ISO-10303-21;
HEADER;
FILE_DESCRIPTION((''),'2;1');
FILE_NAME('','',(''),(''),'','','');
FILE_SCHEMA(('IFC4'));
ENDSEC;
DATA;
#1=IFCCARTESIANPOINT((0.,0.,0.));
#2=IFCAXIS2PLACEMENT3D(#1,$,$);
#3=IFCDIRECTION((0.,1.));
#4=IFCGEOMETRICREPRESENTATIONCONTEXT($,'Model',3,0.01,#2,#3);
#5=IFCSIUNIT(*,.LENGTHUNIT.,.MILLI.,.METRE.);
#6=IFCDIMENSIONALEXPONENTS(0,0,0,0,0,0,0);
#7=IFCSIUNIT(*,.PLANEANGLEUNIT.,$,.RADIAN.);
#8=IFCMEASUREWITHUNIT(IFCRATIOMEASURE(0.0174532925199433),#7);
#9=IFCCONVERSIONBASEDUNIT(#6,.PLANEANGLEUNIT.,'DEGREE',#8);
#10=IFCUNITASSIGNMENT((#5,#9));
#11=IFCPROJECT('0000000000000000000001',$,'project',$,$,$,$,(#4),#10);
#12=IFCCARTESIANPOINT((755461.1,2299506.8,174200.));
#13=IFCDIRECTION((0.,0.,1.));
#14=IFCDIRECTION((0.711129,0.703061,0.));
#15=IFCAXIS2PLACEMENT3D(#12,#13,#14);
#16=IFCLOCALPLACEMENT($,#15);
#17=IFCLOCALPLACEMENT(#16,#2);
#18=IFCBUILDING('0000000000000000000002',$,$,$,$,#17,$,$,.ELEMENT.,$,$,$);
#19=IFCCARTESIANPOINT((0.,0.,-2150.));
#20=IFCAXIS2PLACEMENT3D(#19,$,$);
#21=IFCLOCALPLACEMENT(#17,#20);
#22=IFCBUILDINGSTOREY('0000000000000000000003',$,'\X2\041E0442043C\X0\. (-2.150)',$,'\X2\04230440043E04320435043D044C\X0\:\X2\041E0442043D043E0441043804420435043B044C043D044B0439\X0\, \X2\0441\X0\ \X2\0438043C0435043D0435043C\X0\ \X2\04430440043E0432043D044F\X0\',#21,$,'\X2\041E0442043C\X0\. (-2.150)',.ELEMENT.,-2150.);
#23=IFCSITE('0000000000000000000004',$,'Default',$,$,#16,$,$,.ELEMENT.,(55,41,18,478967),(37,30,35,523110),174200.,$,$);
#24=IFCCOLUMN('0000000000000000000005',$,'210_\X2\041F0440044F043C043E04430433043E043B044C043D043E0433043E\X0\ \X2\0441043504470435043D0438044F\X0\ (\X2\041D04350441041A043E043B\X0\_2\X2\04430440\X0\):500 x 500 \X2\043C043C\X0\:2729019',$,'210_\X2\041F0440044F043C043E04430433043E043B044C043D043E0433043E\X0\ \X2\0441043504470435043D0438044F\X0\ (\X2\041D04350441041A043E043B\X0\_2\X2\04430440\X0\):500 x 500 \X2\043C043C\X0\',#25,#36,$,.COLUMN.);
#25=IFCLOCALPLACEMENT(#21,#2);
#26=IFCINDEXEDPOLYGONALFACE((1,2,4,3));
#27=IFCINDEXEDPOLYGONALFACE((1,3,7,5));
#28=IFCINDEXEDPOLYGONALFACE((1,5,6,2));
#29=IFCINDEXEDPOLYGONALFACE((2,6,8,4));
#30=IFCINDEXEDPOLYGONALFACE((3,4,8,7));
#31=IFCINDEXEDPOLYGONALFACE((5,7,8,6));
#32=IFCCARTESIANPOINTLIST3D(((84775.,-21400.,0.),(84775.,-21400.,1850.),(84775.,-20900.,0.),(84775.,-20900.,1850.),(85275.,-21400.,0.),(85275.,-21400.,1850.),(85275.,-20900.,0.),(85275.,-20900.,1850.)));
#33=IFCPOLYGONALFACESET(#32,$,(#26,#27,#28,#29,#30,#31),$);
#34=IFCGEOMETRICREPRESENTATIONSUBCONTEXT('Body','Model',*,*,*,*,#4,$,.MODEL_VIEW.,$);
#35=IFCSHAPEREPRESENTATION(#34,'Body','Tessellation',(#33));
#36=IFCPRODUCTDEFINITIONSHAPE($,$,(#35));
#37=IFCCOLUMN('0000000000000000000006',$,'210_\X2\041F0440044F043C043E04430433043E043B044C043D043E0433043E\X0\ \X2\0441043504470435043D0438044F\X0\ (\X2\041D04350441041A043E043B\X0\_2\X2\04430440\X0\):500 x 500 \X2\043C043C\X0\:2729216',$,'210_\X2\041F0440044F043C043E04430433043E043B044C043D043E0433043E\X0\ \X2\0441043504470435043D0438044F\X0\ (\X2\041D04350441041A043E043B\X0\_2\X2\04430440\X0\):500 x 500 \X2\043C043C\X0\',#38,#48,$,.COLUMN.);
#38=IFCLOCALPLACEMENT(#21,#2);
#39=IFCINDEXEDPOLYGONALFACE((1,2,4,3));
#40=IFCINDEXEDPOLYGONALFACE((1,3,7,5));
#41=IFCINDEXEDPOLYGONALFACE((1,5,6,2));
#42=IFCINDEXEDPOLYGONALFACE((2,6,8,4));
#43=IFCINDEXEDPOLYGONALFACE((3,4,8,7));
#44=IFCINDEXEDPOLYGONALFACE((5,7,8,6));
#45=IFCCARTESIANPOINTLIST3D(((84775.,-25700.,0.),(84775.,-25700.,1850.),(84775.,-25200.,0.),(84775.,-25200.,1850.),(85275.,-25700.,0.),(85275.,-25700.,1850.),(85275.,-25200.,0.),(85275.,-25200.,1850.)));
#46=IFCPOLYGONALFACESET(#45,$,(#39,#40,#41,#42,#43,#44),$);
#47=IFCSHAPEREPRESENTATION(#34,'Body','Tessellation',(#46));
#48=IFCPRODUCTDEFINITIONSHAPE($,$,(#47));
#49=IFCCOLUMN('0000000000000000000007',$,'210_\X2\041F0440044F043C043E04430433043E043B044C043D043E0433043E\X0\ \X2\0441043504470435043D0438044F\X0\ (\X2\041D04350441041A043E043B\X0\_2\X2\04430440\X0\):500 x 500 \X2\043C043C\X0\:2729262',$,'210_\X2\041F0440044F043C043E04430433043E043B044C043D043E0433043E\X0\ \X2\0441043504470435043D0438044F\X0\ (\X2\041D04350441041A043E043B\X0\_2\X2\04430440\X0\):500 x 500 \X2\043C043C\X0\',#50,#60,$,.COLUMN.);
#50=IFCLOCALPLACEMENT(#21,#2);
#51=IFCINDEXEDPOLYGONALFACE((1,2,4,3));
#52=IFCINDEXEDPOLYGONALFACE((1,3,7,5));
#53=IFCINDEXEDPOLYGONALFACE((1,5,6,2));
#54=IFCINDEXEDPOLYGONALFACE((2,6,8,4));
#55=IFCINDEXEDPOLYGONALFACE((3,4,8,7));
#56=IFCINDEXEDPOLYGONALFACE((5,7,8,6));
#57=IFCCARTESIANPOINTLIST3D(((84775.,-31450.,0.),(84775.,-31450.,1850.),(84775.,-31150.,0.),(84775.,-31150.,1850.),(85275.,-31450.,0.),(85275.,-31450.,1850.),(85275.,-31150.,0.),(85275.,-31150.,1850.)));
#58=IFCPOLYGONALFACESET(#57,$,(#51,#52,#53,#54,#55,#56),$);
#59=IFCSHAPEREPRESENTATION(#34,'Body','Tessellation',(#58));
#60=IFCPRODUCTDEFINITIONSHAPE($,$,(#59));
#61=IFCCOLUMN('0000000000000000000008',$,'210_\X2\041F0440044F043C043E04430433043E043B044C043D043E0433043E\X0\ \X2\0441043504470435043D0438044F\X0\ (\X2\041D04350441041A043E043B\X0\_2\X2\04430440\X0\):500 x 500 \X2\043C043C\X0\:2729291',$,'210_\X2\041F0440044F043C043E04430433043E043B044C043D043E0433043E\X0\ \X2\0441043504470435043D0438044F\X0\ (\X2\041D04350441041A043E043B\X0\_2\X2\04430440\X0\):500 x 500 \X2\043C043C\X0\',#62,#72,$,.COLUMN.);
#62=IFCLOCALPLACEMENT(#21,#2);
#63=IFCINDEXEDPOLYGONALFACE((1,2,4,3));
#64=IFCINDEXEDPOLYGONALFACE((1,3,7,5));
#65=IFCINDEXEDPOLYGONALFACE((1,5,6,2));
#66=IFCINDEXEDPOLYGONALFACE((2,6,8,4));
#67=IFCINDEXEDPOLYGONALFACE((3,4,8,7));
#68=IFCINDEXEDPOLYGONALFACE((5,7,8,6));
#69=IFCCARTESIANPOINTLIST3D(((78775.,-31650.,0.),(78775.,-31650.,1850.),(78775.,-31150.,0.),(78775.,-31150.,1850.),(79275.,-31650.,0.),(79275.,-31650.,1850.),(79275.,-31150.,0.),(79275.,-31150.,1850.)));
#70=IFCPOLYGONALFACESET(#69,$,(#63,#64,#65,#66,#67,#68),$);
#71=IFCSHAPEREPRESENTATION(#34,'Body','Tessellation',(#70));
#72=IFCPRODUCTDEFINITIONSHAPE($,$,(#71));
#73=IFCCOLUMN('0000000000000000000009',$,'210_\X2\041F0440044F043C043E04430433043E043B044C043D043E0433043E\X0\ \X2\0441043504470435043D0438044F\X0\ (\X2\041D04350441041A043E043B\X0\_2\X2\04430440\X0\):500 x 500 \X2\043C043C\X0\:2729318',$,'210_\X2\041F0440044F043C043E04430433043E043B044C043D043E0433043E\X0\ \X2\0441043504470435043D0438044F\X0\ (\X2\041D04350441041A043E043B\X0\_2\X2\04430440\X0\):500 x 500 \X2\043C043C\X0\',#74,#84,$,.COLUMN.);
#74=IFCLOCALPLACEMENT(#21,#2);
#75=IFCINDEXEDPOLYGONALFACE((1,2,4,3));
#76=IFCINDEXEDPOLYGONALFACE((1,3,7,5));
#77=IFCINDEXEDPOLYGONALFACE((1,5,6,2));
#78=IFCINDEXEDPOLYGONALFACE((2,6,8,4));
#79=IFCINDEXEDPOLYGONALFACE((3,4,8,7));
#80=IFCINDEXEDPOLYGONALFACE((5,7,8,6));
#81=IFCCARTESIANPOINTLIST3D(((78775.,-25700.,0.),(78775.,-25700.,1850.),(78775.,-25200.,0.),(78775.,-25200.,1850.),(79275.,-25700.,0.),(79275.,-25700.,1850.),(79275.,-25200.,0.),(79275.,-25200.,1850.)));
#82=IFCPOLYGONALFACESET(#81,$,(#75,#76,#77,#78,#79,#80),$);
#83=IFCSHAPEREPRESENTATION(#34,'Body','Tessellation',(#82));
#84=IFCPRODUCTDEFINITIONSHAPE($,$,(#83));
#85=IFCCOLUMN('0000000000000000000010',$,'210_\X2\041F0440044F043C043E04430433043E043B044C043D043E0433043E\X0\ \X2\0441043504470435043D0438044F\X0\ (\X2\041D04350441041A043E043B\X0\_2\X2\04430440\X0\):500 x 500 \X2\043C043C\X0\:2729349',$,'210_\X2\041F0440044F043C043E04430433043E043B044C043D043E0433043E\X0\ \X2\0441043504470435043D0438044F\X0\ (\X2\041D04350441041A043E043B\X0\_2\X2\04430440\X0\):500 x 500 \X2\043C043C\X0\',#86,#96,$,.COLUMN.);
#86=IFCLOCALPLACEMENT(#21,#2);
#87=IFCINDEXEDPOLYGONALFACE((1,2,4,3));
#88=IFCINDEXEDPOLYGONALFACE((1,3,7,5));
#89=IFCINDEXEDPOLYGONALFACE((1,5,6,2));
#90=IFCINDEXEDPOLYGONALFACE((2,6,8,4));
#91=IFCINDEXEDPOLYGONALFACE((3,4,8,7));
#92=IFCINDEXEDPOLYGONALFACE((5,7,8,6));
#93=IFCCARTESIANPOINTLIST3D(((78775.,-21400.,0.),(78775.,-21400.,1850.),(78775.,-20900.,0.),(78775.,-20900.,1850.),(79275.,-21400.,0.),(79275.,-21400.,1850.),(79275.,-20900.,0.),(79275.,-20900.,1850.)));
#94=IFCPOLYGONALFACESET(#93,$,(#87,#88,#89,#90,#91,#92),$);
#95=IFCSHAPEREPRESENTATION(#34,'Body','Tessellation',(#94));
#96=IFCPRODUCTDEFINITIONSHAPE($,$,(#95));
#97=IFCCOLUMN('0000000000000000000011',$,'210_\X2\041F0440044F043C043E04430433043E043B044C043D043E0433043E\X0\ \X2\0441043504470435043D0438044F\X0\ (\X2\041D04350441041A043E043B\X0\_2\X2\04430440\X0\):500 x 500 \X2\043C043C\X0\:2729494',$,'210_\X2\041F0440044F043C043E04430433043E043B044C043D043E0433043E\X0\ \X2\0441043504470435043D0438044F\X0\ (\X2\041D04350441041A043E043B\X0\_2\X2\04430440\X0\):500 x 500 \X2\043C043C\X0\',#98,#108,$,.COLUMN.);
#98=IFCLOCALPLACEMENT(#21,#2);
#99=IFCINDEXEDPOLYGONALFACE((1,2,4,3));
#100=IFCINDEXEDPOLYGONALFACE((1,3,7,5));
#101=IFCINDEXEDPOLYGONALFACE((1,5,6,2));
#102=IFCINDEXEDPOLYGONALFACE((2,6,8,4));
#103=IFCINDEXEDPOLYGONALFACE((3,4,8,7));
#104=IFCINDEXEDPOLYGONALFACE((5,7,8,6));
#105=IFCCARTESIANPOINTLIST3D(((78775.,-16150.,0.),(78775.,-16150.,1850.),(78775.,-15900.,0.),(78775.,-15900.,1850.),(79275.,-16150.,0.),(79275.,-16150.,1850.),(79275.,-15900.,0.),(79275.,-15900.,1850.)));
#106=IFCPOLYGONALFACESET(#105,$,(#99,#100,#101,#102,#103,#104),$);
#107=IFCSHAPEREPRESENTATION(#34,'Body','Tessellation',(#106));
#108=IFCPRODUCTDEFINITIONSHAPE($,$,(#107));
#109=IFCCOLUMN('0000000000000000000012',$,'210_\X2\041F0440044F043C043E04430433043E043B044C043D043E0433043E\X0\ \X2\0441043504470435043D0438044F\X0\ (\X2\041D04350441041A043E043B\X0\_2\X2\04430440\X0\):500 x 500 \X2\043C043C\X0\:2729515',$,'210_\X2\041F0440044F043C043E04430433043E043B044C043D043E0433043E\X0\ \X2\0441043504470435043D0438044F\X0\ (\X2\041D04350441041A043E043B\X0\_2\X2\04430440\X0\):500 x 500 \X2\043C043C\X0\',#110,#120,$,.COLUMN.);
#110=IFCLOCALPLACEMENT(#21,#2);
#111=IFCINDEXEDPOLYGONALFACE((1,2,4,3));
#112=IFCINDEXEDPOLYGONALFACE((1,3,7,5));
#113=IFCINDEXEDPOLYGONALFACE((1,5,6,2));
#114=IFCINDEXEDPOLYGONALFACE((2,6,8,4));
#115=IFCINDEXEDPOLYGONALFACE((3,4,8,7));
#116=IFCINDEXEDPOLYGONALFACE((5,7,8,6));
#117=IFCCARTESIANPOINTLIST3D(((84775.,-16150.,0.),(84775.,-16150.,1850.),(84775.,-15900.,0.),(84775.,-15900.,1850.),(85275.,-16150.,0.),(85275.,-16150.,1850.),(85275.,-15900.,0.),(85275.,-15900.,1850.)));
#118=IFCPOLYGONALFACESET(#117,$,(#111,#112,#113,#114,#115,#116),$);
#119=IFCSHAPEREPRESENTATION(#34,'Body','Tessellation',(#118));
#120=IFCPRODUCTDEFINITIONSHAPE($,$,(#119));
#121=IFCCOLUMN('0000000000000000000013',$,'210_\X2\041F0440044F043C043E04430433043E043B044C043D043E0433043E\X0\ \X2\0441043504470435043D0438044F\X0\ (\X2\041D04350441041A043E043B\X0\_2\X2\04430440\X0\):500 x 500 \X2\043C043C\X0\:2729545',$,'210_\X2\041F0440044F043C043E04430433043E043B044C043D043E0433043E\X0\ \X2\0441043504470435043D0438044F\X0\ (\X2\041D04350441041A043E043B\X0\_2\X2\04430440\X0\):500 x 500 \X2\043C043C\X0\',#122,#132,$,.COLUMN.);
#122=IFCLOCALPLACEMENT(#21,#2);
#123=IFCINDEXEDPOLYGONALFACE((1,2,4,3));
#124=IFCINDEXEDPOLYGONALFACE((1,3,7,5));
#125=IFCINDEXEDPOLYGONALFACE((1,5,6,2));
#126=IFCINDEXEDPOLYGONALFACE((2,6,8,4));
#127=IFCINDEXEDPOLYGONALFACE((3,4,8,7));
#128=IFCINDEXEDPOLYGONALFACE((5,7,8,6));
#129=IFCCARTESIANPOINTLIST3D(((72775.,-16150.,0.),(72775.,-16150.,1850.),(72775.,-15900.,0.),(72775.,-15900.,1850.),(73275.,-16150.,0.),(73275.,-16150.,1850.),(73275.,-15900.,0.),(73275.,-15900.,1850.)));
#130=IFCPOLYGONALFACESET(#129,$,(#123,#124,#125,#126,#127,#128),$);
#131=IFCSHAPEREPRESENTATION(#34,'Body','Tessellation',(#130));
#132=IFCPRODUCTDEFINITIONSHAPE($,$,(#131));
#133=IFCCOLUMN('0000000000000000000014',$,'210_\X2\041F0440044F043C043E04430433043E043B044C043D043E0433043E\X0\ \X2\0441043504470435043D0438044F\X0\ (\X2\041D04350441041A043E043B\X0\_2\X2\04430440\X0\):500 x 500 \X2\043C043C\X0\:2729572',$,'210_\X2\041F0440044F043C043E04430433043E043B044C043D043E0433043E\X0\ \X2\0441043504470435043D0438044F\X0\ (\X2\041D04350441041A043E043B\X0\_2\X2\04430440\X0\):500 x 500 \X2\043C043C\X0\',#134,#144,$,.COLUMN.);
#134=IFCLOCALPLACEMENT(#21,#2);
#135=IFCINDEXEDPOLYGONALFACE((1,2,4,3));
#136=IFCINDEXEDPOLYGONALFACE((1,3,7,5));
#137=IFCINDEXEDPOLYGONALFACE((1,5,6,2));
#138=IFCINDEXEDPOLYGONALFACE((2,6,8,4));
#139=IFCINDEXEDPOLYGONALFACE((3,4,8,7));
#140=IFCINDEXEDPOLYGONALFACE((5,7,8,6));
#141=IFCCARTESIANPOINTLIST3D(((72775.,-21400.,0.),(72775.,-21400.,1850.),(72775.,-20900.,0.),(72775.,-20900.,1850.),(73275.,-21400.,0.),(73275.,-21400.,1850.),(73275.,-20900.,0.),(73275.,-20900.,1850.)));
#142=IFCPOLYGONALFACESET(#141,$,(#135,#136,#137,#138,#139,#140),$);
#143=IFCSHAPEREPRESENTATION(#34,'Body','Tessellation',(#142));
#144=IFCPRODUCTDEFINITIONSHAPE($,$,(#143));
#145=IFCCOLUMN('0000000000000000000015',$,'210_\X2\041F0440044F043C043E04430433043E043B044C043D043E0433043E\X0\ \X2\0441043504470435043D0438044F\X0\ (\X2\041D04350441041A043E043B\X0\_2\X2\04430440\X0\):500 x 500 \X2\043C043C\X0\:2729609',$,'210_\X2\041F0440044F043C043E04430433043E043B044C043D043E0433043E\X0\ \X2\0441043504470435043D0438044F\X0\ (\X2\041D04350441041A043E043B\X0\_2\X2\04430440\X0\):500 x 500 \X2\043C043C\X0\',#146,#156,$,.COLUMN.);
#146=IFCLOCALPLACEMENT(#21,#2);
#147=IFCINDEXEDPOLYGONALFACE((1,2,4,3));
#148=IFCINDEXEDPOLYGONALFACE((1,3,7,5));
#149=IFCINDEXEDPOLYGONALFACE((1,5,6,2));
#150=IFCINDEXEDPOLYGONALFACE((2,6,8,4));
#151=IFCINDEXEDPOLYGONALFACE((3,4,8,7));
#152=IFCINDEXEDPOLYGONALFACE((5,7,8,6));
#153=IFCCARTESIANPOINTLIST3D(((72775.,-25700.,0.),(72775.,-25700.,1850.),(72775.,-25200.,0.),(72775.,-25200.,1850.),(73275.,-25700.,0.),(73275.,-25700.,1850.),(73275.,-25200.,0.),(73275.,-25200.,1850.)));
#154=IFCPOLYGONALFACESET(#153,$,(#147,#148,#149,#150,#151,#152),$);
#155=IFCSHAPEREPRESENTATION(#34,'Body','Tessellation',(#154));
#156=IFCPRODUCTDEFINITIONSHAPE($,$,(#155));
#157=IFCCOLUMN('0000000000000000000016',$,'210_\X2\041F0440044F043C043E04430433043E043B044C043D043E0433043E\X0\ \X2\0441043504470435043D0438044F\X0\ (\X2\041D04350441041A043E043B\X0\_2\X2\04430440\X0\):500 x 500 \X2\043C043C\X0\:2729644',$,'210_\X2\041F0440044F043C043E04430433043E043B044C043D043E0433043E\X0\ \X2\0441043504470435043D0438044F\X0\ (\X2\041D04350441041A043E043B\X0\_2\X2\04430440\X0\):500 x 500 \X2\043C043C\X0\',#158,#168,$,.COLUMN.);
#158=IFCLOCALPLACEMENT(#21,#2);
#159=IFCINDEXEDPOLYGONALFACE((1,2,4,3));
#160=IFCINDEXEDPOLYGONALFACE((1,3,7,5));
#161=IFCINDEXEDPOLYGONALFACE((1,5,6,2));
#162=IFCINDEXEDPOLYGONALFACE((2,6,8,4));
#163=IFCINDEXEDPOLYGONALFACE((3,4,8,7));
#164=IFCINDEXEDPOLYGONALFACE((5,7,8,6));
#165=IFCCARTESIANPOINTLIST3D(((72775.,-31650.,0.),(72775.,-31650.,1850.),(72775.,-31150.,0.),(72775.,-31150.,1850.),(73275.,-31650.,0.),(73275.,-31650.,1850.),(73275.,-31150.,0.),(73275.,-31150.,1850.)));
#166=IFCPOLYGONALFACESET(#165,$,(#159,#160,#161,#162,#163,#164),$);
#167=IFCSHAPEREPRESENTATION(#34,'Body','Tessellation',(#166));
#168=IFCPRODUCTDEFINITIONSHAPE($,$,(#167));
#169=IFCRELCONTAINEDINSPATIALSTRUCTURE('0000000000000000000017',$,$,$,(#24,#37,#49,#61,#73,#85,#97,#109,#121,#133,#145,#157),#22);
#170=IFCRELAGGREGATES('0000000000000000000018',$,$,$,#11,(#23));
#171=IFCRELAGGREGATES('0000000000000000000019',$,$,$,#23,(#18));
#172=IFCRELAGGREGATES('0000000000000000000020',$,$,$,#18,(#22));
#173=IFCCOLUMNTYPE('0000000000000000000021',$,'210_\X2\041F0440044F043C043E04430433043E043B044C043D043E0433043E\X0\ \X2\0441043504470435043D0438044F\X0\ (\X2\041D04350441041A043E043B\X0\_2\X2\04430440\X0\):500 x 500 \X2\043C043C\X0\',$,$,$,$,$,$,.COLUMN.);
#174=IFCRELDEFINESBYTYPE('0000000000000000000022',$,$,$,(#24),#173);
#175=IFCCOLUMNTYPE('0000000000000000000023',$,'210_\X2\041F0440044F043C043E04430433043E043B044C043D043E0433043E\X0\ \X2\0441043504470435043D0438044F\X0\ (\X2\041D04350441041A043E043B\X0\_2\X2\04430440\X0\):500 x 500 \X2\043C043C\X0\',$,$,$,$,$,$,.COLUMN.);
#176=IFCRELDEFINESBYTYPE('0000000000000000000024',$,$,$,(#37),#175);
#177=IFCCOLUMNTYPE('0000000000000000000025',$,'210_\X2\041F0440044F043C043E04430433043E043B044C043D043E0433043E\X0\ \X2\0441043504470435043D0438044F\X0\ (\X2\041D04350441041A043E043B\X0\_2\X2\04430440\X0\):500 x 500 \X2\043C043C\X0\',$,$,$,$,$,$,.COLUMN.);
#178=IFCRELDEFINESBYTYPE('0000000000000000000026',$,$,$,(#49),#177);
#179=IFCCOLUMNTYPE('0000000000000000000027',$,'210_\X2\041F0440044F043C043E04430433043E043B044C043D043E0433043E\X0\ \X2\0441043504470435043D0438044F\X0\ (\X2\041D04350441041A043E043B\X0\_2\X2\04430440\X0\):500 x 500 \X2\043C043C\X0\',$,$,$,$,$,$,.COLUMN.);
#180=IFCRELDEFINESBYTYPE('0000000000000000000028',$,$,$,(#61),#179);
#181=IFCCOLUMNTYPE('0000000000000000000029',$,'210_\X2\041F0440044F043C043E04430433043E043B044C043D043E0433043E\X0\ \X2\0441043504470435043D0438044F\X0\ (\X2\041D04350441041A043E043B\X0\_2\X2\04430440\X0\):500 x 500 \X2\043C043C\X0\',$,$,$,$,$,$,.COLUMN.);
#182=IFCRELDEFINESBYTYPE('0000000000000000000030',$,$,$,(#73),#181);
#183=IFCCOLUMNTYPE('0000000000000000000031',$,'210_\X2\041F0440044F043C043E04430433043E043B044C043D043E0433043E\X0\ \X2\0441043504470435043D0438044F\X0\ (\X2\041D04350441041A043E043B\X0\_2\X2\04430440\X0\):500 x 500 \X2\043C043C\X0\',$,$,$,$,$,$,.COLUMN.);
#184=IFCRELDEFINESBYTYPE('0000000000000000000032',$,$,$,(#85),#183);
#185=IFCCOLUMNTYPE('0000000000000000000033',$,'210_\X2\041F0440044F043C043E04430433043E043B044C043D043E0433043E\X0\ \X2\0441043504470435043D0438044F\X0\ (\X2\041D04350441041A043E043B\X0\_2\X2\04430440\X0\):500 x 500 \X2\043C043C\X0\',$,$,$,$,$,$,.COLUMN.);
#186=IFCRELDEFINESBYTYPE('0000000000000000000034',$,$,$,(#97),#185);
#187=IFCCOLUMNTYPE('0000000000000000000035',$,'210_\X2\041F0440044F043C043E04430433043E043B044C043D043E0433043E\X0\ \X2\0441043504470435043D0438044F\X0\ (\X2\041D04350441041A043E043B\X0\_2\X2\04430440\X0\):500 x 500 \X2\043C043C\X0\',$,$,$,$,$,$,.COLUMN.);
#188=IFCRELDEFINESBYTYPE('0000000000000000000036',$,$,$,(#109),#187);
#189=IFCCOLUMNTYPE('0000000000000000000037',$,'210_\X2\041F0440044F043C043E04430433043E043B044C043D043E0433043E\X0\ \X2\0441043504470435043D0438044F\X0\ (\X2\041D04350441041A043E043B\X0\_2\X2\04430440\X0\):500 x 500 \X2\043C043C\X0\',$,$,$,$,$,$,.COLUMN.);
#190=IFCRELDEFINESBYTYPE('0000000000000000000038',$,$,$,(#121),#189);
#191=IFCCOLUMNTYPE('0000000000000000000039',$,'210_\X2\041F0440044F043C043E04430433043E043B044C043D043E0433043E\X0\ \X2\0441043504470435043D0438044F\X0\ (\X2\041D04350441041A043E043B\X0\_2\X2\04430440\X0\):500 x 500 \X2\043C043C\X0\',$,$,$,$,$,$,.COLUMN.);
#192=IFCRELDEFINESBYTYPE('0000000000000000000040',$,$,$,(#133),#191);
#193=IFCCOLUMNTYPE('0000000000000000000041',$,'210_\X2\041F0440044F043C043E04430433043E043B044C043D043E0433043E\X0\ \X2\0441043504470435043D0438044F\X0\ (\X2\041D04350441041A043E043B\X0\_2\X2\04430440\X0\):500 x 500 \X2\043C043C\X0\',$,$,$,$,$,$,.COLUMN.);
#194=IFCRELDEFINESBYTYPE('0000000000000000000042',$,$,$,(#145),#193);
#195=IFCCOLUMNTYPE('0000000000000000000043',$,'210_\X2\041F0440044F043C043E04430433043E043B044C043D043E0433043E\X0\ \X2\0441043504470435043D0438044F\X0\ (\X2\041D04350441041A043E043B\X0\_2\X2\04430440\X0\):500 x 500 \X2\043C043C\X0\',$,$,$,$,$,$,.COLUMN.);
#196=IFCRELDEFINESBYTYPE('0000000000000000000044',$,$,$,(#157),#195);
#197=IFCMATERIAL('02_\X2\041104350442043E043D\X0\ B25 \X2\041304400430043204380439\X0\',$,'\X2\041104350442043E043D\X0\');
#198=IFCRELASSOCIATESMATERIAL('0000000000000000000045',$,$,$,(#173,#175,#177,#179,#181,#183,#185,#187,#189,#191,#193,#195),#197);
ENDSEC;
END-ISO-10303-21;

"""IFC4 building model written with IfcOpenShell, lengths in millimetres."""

from ifc_helpers import new_model, entity, si_unit, converted_unit, direction, frame, origin, place, context, subcontext, project, spatial, indexed_curve, outline, extrude, source, transform, mapped, material, type_object, type_shapes, element, save


model = new_model("IFC4")

# Units and contexts
model_context = context("Model", 3, precision=0.01, world=origin(), true_north=direction((0.0, 1.0)))
body_context = subcontext(model_context, "Body", "Model", "MODEL_VIEW")
ifc_project = project(units=[si_unit("LENGTHUNIT", "METRE", prefix="MILLI"), converted_unit("PLANEANGLEUNIT", "DEGREE", entity("IfcRatioMeasure", 0.0174532925199433), si_unit("PLANEANGLEUNIT", "RADIAN"), dimensions=[0, 0, 0, 0, 0, 0, 0])], contexts=[model_context])

# Site, building, storey
site_placement = place(None, frame((755461.1, 2299506.8, 174200.0), z_axis=(0.0, 0.0, 1.0), x_axis=(0.711129, 0.703061, 0.0)))
site = spatial("IfcSite", under=ifc_project, at=site_placement, Name="Default", CompositionType="ELEMENT", RefLatitude=(55, 41, 18, 478967), RefLongitude=(37, 30, 35, 523110), RefElevation=174200.0)
building_placement = place(site_placement, origin())
building = spatial("IfcBuilding", under=site, at=building_placement, CompositionType="ELEMENT")
storey_placement = place(building_placement, frame((0.0, 0.0, -2150.0)))
storey = spatial("IfcBuildingStorey", under=building, at=storey_placement, Name="Отм. (-2.150)", ObjectType="Уровень:Относительный, с именем уровня", LongName="Отм. (-2.150)", CompositionType="ELEMENT", Elevation=-2150.0)

# Columns
ifc_material_1 = material(Name="02_Бетон B25 Гравий", Category="Бетон")
column_type_1 = type_object("IfcColumnType", Name="210_Прямоугольного сечения (НесКол_2ур):500 x 500 мм", PredefinedType="COLUMN", material=ifc_material_1)
shared_shape_1 = source(origin(), body_context, "Body", "SweptSolid", [
    extrude(outline(indexed_curve([(-250.0, -250.0), (250.0, -250.0), (250.0, 250.0), (-250.0, 250.0), (-250.0, -250.0)], self_intersect=False)), frame((85025.0, -21150.0, -2150.0), z_axis=(0.0, 0.0, 1.0), x_axis=(0.0, -1.0, 0.0)), (0.0, 0.0, 1.0), 1850.0),
])
type_shapes(column_type_1, [shared_shape_1])
column_1_placement = place(storey_placement, frame((0.0, 0.0, 2150.0)))
element("IfcColumn", 1, at=column_1_placement, inside=storey, type_object=column_type_1, Name="210_Прямоугольного сечения (НесКол_2ур):500 x 500 мм:2729019", ObjectType="210_Прямоугольного сечения (НесКол_2ур):500 x 500 мм", PredefinedType="COLUMN", context=body_context, shape_type="MappedRepresentation", body=[
    mapped(shared_shape_1, transform((0.0, 0.0, 0.0), scale=1.0)),
])
column_type_2 = type_object("IfcColumnType", Name="210_Прямоугольного сечения (НесКол_2ур):500 x 500 мм", PredefinedType="COLUMN", material=ifc_material_1)
shared_shape_2 = source(origin(), body_context, "Body", "SweptSolid", [
    extrude(outline(indexed_curve([(-250.0, -250.0), (250.0, -250.0), (250.0, 250.0), (-250.0, 250.0), (-250.0, -250.0)], self_intersect=False)), frame((85025.0, -25450.0, -2150.0), z_axis=(0.0, 0.0, 1.0), x_axis=(0.0, -1.0, 0.0)), (0.0, 0.0, 1.0), 1850.0),
])
type_shapes(column_type_2, [shared_shape_2])
column_2_placement = place(storey_placement, frame((0.0, 0.0, 2150.0)))
element("IfcColumn", 2, at=column_2_placement, inside=storey, type_object=column_type_2, Name="210_Прямоугольного сечения (НесКол_2ур):500 x 500 мм:2729216", ObjectType="210_Прямоугольного сечения (НесКол_2ур):500 x 500 мм", PredefinedType="COLUMN", context=body_context, shape_type="MappedRepresentation", body=[
    mapped(shared_shape_2, transform((0.0, 0.0, 0.0), scale=1.0)),
])
column_type_3 = type_object("IfcColumnType", Name="210_Прямоугольного сечения (НесКол_2ур):500 x 500 мм", PredefinedType="COLUMN", material=ifc_material_1)
shared_shape_3 = source(origin(), body_context, "Body", "SweptSolid", [
    extrude(outline(indexed_curve([(-150.0, -250.0), (150.0, -250.0), (150.0, 250.0), (-150.0, 250.0), (-150.0, -250.0)], self_intersect=False)), frame((85025.0, -31300.0, -2150.0), z_axis=(0.0, 0.0, 1.0), x_axis=(0.0, -1.0, 0.0)), (0.0, 0.0, 1.0), 1850.0),
])
type_shapes(column_type_3, [shared_shape_3])
column_3_placement = place(storey_placement, frame((0.0, 0.0, 2150.0)))
element("IfcColumn", 3, at=column_3_placement, inside=storey, type_object=column_type_3, Name="210_Прямоугольного сечения (НесКол_2ур):500 x 500 мм:2729262", ObjectType="210_Прямоугольного сечения (НесКол_2ур):500 x 500 мм", PredefinedType="COLUMN", context=body_context, shape_type="MappedRepresentation", body=[
    mapped(shared_shape_3, transform((0.0, 0.0, 0.0), scale=1.0)),
])
column_type_4 = type_object("IfcColumnType", Name="210_Прямоугольного сечения (НесКол_2ур):500 x 500 мм", PredefinedType="COLUMN", material=ifc_material_1)
shared_shape_4 = source(origin(), body_context, "Body", "SweptSolid", [
    extrude(outline(indexed_curve([(-250.0, -250.0), (250.0, -250.0), (250.0, 250.0), (-250.0, 250.0), (-250.0, -250.0)], self_intersect=False)), frame((79025.0, -31400.0, -2150.0), z_axis=(0.0, 0.0, 1.0), x_axis=(0.0, -1.0, 0.0)), (0.0, 0.0, 1.0), 1850.0),
])
type_shapes(column_type_4, [shared_shape_4])
column_4_placement = place(storey_placement, frame((0.0, 0.0, 2150.0)))
element("IfcColumn", 4, at=column_4_placement, inside=storey, type_object=column_type_4, Name="210_Прямоугольного сечения (НесКол_2ур):500 x 500 мм:2729291", ObjectType="210_Прямоугольного сечения (НесКол_2ур):500 x 500 мм", PredefinedType="COLUMN", context=body_context, shape_type="MappedRepresentation", body=[
    mapped(shared_shape_4, transform((0.0, 0.0, 0.0), scale=1.0)),
])
column_type_5 = type_object("IfcColumnType", Name="210_Прямоугольного сечения (НесКол_2ур):500 x 500 мм", PredefinedType="COLUMN", material=ifc_material_1)
shared_shape_5 = source(origin(), body_context, "Body", "SweptSolid", [
    extrude(outline(indexed_curve([(-250.0, -250.0), (250.0, -250.0), (250.0, 250.0), (-250.0, 250.0), (-250.0, -250.0)], self_intersect=False)), frame((79025.0, -25450.0, -2150.0), z_axis=(0.0, 0.0, 1.0), x_axis=(0.0, -1.0, 0.0)), (0.0, 0.0, 1.0), 1850.0),
])
type_shapes(column_type_5, [shared_shape_5])
column_5_placement = place(storey_placement, frame((0.0, 0.0, 2150.0)))
element("IfcColumn", 5, at=column_5_placement, inside=storey, type_object=column_type_5, Name="210_Прямоугольного сечения (НесКол_2ур):500 x 500 мм:2729318", ObjectType="210_Прямоугольного сечения (НесКол_2ур):500 x 500 мм", PredefinedType="COLUMN", context=body_context, shape_type="MappedRepresentation", body=[
    mapped(shared_shape_5, transform((0.0, 0.0, 0.0), scale=1.0)),
])
column_type_6 = type_object("IfcColumnType", Name="210_Прямоугольного сечения (НесКол_2ур):500 x 500 мм", PredefinedType="COLUMN", material=ifc_material_1)
shared_shape_6 = source(origin(), body_context, "Body", "SweptSolid", [
    extrude(outline(indexed_curve([(-250.0, -250.0), (250.0, -250.0), (250.0, 250.0), (-250.0, 250.0), (-250.0, -250.0)], self_intersect=False)), frame((79025.0, -21150.0, -2150.0), z_axis=(0.0, 0.0, 1.0), x_axis=(0.0, -1.0, 0.0)), (0.0, 0.0, 1.0), 1850.0),
])
type_shapes(column_type_6, [shared_shape_6])
column_6_placement = place(storey_placement, frame((0.0, 0.0, 2150.0)))
element("IfcColumn", 6, at=column_6_placement, inside=storey, type_object=column_type_6, Name="210_Прямоугольного сечения (НесКол_2ур):500 x 500 мм:2729349", ObjectType="210_Прямоугольного сечения (НесКол_2ур):500 x 500 мм", PredefinedType="COLUMN", context=body_context, shape_type="MappedRepresentation", body=[
    mapped(shared_shape_6, transform((0.0, 0.0, 0.0), scale=1.0)),
])
column_type_7 = type_object("IfcColumnType", Name="210_Прямоугольного сечения (НесКол_2ур):500 x 500 мм", PredefinedType="COLUMN", material=ifc_material_1)
shared_shape_7 = source(origin(), body_context, "Body", "SweptSolid", [
    extrude(outline(indexed_curve([(-125.0, -250.0), (125.0, -250.0), (125.0, 250.0), (-125.0, 250.0), (-125.0, -250.0)], self_intersect=False)), frame((79025.0, -16025.0, -2150.0), z_axis=(0.0, 0.0, 1.0), x_axis=(0.0, -1.0, 0.0)), (0.0, 0.0, 1.0), 1850.0),
])
type_shapes(column_type_7, [shared_shape_7])
column_7_placement = place(storey_placement, frame((0.0, 0.0, 2150.0)))
element("IfcColumn", 7, at=column_7_placement, inside=storey, type_object=column_type_7, Name="210_Прямоугольного сечения (НесКол_2ур):500 x 500 мм:2729494", ObjectType="210_Прямоугольного сечения (НесКол_2ур):500 x 500 мм", PredefinedType="COLUMN", context=body_context, shape_type="MappedRepresentation", body=[
    mapped(shared_shape_7, transform((0.0, 0.0, 0.0), scale=1.0)),
])
column_type_8 = type_object("IfcColumnType", Name="210_Прямоугольного сечения (НесКол_2ур):500 x 500 мм", PredefinedType="COLUMN", material=ifc_material_1)
shared_shape_8 = source(origin(), body_context, "Body", "SweptSolid", [
    extrude(outline(indexed_curve([(-125.0, -250.0), (125.0, -250.0), (125.0, 250.0), (-125.0, 250.0), (-125.0, -250.0)], self_intersect=False)), frame((85025.0, -16025.0, -2150.0), z_axis=(0.0, 0.0, 1.0), x_axis=(0.0, -1.0, 0.0)), (0.0, 0.0, 1.0), 1850.0),
])
type_shapes(column_type_8, [shared_shape_8])
column_8_placement = place(storey_placement, frame((0.0, 0.0, 2150.0)))
element("IfcColumn", 8, at=column_8_placement, inside=storey, type_object=column_type_8, Name="210_Прямоугольного сечения (НесКол_2ур):500 x 500 мм:2729515", ObjectType="210_Прямоугольного сечения (НесКол_2ур):500 x 500 мм", PredefinedType="COLUMN", context=body_context, shape_type="MappedRepresentation", body=[
    mapped(shared_shape_8, transform((0.0, 0.0, 0.0), scale=1.0)),
])
column_type_9 = type_object("IfcColumnType", Name="210_Прямоугольного сечения (НесКол_2ур):500 x 500 мм", PredefinedType="COLUMN", material=ifc_material_1)
shared_shape_9 = source(origin(), body_context, "Body", "SweptSolid", [
    extrude(outline(indexed_curve([(-125.0, -250.0), (125.0, -250.0), (125.0, 250.0), (-125.0, 250.0), (-125.0, -250.0)], self_intersect=False)), frame((73025.0, -16025.0, -2150.0), z_axis=(0.0, 0.0, 1.0), x_axis=(0.0, -1.0, 0.0)), (0.0, 0.0, 1.0), 1850.0),
])
type_shapes(column_type_9, [shared_shape_9])
column_9_placement = place(storey_placement, frame((0.0, 0.0, 2150.0)))
element("IfcColumn", 9, at=column_9_placement, inside=storey, type_object=column_type_9, Name="210_Прямоугольного сечения (НесКол_2ур):500 x 500 мм:2729545", ObjectType="210_Прямоугольного сечения (НесКол_2ур):500 x 500 мм", PredefinedType="COLUMN", context=body_context, shape_type="MappedRepresentation", body=[
    mapped(shared_shape_9, transform((0.0, 0.0, 0.0), scale=1.0)),
])
column_type_10 = type_object("IfcColumnType", Name="210_Прямоугольного сечения (НесКол_2ур):500 x 500 мм", PredefinedType="COLUMN", material=ifc_material_1)
shared_shape_10 = source(origin(), body_context, "Body", "SweptSolid", [
    extrude(outline(indexed_curve([(-250.0, -250.0), (250.0, -250.0), (250.0, 250.0), (-250.0, 250.0), (-250.0, -250.0)], self_intersect=False)), frame((73025.0, -21150.0, -2150.0), z_axis=(0.0, 0.0, 1.0), x_axis=(0.0, -1.0, 0.0)), (0.0, 0.0, 1.0), 1850.0),
])
type_shapes(column_type_10, [shared_shape_10])
column_10_placement = place(storey_placement, frame((0.0, 0.0, 2150.0)))
element("IfcColumn", 10, at=column_10_placement, inside=storey, type_object=column_type_10, Name="210_Прямоугольного сечения (НесКол_2ур):500 x 500 мм:2729572", ObjectType="210_Прямоугольного сечения (НесКол_2ур):500 x 500 мм", PredefinedType="COLUMN", context=body_context, shape_type="MappedRepresentation", body=[
    mapped(shared_shape_10, transform((0.0, 0.0, 0.0), scale=1.0)),
])
column_type_11 = type_object("IfcColumnType", Name="210_Прямоугольного сечения (НесКол_2ур):500 x 500 мм", PredefinedType="COLUMN", material=ifc_material_1)
shared_shape_11 = source(origin(), body_context, "Body", "SweptSolid", [
    extrude(outline(indexed_curve([(-250.0, -250.0), (250.0, -250.0), (250.0, 250.0), (-250.0, 250.0), (-250.0, -250.0)], self_intersect=False)), frame((73025.0, -25450.0, -2150.0), z_axis=(0.0, 0.0, 1.0), x_axis=(0.0, -1.0, 0.0)), (0.0, 0.0, 1.0), 1850.0),
])
type_shapes(column_type_11, [shared_shape_11])
column_11_placement = place(storey_placement, frame((0.0, 0.0, 2150.0)))
element("IfcColumn", 11, at=column_11_placement, inside=storey, type_object=column_type_11, Name="210_Прямоугольного сечения (НесКол_2ур):500 x 500 мм:2729609", ObjectType="210_Прямоугольного сечения (НесКол_2ур):500 x 500 мм", PredefinedType="COLUMN", context=body_context, shape_type="MappedRepresentation", body=[
    mapped(shared_shape_11, transform((0.0, 0.0, 0.0), scale=1.0)),
])
column_type_12 = type_object("IfcColumnType", Name="210_Прямоугольного сечения (НесКол_2ур):500 x 500 мм", PredefinedType="COLUMN", material=ifc_material_1)
shared_shape_12 = source(origin(), body_context, "Body", "SweptSolid", [
    extrude(outline(indexed_curve([(-250.0, -250.0), (250.0, -250.0), (250.0, 250.0), (-250.0, 250.0), (-250.0, -250.0)], self_intersect=False)), frame((73025.0, -31400.0, -2150.0), z_axis=(0.0, 0.0, 1.0), x_axis=(0.0, -1.0, 0.0)), (0.0, 0.0, 1.0), 1850.0),
])
type_shapes(column_type_12, [shared_shape_12])
column_12_placement = place(storey_placement, frame((0.0, 0.0, 2150.0)))
element("IfcColumn", 12, at=column_12_placement, inside=storey, type_object=column_type_12, Name="210_Прямоугольного сечения (НесКол_2ур):500 x 500 мм:2729644", ObjectType="210_Прямоугольного сечения (НесКол_2ур):500 x 500 мм", PredefinedType="COLUMN", context=body_context, shape_type="MappedRepresentation", body=[
    mapped(shared_shape_12, transform((0.0, 0.0, 0.0), scale=1.0)),
])

save(model, "model.ifc")
